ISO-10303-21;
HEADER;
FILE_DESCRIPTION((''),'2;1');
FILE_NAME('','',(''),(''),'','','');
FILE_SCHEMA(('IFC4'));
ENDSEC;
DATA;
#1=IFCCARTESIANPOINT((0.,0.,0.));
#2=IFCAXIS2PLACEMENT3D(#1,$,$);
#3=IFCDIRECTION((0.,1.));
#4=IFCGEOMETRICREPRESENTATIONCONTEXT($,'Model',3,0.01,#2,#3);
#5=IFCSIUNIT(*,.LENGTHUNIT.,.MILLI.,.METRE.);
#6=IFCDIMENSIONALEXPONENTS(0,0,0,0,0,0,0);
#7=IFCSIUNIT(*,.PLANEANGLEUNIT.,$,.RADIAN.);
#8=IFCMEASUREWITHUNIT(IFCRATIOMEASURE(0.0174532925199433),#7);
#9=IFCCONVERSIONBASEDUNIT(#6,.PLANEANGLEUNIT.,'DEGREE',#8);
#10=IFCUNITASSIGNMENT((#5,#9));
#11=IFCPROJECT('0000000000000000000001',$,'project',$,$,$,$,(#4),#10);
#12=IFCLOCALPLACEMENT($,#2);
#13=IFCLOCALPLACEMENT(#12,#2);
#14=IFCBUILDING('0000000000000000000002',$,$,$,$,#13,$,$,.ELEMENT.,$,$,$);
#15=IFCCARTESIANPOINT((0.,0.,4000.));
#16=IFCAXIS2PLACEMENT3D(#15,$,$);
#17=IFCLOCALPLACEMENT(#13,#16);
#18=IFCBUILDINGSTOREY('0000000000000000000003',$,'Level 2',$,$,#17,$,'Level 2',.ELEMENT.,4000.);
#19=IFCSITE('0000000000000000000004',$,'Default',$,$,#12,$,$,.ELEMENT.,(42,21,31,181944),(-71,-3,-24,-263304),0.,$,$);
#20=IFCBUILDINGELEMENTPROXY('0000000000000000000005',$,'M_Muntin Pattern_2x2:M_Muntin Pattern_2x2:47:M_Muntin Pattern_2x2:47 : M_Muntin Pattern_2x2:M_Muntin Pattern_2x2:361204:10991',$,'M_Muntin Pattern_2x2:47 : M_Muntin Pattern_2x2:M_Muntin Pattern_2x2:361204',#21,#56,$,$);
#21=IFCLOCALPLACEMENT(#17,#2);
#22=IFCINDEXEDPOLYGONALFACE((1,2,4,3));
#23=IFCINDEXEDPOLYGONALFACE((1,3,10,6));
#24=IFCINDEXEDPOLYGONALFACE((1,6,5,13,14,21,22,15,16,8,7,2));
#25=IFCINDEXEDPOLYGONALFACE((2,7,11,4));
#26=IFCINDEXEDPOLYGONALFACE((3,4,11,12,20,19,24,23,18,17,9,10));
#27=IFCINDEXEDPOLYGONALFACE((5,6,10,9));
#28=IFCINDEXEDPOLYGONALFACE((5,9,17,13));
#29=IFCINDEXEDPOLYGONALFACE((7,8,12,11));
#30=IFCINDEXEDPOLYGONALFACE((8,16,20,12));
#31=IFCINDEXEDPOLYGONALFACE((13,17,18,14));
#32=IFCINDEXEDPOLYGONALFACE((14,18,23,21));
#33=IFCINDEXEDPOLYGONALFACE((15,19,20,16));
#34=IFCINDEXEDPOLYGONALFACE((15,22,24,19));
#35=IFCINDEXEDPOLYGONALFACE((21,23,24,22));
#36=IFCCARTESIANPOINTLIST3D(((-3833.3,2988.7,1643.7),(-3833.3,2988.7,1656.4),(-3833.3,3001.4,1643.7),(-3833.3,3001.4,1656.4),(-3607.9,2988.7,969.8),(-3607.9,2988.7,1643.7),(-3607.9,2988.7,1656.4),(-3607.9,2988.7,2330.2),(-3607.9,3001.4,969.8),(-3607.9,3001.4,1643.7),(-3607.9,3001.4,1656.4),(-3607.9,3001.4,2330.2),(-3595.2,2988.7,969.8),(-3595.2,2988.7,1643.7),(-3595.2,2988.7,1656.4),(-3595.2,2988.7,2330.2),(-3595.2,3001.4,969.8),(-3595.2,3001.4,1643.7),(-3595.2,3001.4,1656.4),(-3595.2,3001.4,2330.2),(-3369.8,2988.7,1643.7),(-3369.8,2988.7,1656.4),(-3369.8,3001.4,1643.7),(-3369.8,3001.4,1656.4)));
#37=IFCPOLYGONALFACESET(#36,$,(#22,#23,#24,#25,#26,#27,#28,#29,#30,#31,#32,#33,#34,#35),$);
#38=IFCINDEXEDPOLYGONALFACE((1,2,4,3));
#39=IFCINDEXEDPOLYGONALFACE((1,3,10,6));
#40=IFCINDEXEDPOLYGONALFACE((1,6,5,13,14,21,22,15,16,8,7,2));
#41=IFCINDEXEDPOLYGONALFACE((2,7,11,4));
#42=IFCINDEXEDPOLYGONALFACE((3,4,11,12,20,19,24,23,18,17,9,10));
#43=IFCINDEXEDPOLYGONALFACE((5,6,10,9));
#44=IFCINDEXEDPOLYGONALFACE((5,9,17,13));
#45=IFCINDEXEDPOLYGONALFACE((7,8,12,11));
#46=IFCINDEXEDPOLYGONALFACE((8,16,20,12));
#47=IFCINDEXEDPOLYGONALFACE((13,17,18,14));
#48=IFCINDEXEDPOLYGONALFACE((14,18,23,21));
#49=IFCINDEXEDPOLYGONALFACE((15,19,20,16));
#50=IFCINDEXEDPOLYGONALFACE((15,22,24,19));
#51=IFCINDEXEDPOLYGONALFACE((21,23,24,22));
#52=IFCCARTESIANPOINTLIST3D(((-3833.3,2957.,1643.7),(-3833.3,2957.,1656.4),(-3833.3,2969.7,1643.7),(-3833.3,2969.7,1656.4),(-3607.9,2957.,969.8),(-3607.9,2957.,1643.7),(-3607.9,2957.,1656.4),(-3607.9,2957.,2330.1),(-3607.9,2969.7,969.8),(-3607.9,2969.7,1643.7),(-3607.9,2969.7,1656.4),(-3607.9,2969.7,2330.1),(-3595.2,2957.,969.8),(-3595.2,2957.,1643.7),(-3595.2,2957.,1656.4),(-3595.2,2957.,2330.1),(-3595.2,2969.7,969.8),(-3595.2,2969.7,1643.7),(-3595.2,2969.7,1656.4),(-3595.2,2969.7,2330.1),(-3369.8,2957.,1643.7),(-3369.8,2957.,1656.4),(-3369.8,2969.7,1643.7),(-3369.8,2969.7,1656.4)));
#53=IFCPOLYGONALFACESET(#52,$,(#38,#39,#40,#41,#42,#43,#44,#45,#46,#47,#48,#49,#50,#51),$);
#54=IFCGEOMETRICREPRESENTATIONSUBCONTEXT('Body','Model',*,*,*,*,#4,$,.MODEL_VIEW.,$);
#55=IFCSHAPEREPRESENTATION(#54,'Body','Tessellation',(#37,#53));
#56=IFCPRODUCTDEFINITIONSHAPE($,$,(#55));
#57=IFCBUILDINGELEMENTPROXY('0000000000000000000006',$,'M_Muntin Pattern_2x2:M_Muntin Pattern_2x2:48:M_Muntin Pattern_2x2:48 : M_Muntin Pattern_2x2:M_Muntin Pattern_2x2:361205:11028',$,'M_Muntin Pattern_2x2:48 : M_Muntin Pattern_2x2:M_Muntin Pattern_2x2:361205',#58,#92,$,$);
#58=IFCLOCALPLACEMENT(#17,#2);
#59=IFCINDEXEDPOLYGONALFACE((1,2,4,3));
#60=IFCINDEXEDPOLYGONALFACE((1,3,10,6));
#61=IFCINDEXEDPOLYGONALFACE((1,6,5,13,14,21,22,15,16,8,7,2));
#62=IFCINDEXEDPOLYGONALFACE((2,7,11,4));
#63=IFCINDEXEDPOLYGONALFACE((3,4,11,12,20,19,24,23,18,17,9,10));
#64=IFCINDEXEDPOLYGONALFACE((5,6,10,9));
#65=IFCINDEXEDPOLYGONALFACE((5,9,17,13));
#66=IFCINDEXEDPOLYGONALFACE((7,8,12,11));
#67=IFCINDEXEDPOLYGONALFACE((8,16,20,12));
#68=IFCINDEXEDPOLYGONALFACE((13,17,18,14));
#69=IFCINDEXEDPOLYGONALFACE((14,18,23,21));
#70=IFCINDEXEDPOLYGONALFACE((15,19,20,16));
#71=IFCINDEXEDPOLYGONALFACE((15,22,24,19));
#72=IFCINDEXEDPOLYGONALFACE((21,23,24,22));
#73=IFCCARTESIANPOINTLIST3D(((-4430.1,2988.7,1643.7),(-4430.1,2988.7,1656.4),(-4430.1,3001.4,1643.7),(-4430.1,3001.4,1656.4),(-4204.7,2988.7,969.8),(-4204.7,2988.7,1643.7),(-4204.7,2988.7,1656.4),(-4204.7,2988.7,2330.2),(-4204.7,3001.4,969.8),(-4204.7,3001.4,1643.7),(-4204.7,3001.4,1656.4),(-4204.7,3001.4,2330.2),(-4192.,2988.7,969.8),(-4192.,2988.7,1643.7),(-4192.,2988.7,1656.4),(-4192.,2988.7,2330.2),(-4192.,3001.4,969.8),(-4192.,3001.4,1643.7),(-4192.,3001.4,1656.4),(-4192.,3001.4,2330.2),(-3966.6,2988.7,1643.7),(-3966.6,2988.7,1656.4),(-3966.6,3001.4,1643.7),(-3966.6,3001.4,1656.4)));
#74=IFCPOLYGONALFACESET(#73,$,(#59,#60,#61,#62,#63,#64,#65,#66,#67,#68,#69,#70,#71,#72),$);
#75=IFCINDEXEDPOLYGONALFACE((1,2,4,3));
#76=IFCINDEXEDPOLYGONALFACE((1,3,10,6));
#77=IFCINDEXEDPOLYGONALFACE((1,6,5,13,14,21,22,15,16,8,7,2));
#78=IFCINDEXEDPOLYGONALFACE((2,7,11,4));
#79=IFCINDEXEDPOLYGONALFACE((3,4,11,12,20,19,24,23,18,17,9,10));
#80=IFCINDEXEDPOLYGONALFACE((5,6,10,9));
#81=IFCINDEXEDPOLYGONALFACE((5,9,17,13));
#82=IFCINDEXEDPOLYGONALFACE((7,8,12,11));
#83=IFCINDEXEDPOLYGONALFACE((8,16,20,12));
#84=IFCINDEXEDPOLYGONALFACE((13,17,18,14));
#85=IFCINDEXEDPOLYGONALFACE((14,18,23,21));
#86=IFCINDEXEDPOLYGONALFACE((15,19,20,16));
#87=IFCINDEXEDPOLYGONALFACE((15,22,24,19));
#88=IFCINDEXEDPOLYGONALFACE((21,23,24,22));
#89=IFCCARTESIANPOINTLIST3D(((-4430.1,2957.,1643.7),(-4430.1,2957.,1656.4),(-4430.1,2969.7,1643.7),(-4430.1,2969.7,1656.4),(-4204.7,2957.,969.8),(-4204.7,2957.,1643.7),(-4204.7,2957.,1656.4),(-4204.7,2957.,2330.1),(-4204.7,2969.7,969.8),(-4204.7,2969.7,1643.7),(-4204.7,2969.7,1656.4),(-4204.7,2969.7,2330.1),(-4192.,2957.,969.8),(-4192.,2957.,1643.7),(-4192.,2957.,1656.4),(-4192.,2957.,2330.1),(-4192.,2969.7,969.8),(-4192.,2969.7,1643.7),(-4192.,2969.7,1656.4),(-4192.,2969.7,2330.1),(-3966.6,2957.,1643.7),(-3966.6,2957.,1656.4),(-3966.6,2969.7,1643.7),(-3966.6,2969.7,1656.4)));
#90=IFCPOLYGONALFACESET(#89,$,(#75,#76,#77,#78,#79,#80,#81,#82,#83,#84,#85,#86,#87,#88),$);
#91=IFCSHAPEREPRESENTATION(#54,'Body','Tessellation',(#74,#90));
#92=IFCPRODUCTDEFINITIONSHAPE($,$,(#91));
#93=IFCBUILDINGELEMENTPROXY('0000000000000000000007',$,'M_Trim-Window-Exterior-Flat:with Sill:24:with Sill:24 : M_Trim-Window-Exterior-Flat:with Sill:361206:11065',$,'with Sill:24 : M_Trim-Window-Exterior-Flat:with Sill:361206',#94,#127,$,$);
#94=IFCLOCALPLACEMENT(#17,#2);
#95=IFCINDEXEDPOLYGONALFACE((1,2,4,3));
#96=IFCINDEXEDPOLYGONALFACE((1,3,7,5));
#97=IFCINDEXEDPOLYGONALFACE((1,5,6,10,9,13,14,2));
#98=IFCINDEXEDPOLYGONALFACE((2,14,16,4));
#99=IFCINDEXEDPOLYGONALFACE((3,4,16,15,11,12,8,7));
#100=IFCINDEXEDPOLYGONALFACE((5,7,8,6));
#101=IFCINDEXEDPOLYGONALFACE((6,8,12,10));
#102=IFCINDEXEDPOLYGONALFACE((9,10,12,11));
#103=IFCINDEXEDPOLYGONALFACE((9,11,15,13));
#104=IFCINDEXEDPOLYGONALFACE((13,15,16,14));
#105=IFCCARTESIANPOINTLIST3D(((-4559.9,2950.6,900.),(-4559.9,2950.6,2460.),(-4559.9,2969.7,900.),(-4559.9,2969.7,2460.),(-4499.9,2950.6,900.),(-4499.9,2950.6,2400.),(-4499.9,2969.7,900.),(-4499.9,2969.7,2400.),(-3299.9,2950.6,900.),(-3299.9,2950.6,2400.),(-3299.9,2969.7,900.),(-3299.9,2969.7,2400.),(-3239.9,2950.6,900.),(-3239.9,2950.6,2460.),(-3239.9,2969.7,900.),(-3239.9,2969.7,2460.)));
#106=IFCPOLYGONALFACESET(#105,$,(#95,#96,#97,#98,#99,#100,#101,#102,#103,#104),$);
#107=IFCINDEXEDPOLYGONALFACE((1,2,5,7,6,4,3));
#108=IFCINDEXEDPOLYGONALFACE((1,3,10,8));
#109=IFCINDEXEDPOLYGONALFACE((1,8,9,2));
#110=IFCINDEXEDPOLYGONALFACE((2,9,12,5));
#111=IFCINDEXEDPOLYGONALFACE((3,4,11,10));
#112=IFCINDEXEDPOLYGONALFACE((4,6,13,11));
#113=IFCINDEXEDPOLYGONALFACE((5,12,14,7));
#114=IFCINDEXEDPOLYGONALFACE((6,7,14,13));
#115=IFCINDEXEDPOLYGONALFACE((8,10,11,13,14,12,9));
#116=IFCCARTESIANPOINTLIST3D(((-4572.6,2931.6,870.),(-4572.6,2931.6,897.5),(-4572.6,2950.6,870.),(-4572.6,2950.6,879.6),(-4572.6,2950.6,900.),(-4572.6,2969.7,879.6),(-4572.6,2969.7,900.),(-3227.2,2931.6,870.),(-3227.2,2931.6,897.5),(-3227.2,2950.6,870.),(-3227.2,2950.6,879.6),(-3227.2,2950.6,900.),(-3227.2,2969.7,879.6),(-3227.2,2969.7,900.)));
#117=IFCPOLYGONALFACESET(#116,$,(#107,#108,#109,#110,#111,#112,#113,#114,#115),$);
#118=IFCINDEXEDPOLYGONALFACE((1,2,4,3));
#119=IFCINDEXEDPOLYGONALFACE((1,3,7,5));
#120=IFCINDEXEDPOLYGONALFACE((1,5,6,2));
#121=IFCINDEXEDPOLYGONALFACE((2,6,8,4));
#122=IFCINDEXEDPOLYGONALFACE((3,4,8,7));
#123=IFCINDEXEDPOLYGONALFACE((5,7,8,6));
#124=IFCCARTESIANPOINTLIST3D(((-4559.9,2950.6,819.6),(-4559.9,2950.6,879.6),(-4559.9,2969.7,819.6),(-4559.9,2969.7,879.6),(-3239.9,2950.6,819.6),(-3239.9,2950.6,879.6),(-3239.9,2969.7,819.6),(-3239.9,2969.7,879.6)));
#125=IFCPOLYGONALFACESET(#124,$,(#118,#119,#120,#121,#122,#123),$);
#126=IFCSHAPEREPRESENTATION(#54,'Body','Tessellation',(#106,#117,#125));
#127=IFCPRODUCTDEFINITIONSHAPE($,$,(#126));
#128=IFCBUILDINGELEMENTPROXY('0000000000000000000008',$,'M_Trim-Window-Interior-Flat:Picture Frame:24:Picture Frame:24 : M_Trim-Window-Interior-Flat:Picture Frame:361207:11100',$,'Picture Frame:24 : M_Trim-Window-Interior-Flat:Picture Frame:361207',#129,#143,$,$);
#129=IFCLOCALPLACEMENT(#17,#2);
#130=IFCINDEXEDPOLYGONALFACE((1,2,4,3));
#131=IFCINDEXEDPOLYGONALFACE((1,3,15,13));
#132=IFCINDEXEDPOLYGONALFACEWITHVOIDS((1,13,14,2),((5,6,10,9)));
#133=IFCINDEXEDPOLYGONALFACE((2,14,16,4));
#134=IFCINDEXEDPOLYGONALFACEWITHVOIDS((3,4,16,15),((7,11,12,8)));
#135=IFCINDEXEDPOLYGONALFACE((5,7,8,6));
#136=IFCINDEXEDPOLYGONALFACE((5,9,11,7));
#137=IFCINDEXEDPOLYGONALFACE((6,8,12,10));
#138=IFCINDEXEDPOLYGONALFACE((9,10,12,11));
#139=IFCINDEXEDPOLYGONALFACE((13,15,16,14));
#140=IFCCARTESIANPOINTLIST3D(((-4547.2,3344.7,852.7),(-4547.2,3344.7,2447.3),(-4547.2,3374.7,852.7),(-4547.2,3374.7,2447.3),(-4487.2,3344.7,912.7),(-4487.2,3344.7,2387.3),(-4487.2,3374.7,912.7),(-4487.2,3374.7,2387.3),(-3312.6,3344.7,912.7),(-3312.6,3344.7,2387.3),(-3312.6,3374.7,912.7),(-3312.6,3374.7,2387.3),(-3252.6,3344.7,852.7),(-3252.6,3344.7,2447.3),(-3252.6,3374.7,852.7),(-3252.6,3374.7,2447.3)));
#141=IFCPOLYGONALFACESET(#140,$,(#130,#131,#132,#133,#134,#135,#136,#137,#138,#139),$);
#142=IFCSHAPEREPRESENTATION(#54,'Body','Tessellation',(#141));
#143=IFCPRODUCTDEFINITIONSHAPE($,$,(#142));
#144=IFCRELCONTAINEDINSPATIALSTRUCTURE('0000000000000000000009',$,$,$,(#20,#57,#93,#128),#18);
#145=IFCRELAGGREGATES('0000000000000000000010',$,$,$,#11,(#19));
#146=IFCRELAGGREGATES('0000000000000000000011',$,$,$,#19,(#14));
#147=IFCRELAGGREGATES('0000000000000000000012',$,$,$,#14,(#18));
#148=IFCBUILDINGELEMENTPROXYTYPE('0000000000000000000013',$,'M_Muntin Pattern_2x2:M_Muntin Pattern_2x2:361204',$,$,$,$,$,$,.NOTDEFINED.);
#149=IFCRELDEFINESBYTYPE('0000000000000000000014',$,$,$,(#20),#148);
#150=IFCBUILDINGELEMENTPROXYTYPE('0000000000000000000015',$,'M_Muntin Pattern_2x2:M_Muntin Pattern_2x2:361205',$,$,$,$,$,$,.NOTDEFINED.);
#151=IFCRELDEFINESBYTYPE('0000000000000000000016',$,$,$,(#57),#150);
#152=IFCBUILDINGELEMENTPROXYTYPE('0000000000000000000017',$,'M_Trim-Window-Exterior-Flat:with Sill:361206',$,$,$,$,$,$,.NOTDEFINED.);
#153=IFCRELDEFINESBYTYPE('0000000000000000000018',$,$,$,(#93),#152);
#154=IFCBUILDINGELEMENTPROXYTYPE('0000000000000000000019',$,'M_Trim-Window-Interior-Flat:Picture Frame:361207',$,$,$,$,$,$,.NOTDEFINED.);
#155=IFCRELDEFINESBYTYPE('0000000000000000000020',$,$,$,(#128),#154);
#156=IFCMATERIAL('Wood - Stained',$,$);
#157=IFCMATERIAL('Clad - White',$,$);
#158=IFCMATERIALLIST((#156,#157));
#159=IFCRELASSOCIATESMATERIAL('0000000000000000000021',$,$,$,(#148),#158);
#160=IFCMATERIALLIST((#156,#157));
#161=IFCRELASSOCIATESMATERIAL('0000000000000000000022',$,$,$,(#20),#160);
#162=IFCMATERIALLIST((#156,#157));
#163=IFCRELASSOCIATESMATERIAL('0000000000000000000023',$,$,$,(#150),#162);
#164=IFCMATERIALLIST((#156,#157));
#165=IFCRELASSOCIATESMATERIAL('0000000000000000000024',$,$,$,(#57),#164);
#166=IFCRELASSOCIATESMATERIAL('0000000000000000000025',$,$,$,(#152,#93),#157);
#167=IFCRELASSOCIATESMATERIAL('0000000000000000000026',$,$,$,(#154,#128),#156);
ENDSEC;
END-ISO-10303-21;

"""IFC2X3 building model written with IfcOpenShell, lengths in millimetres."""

from ifc_helpers import new_model, entity, si_unit, converted_unit, direction, frame, origin, origin_2d_with_axis, place, context, subcontext, project, spatial, polyline, rectangle, outline, extrude, source, transform, mapped, material, material_list, type_object, type_shapes, element, save


model = new_model("IFC2X3")

# Units and contexts
model_context = context("Model", 3, precision=0.01, world=origin(), true_north=direction((0.0, 1.0)))
body_context = subcontext(model_context, "Body", "Model", "MODEL_VIEW")
ifc_project = project(units=[si_unit("LENGTHUNIT", "METRE", prefix="MILLI"), converted_unit("PLANEANGLEUNIT", "DEGREE", entity("IfcRatioMeasure", 0.0174532925199433), si_unit("PLANEANGLEUNIT", "RADIAN"), dimensions=[0, 0, 0, 0, 0, 0, 0])], contexts=[model_context])

# Site, building, storey
site_placement = place(None, origin())
site = spatial("IfcSite", under=ifc_project, at=site_placement, Name="Default", CompositionType="ELEMENT", RefLatitude=(42, 21, 31, 181944), RefLongitude=(-71, -3, -24, -263304), RefElevation=0.0)
building_placement = place(site_placement, origin())
building = spatial("IfcBuilding", under=site, at=building_placement, CompositionType="ELEMENT")
storey_placement = place(building_placement, frame((0.0, 0.0, 4000.0)))
storey = spatial("IfcBuildingStorey", under=building, at=storey_placement, Name="Level 2", LongName="Level 2", CompositionType="ELEMENT", Elevation=4000.0)

# Building element proxies
ifc_material_1 = material(Name="Wood - Stained")
ifc_material_2 = material(Name="Clad - White")
ifc_material_list_1 = material_list([ifc_material_1, ifc_material_2])
ifc_material_list_2 = material_list([ifc_material_1, ifc_material_2])
building_element_proxy_type_1 = type_object("IfcBuildingElementProxyType", Name="M_Muntin Pattern_2x2:M_Muntin Pattern_2x2:361204", PredefinedType="NOTDEFINED", material=ifc_material_list_2)
shared_shape_1 = source(origin(), body_context, "Body", "SweptSolid", [
    extrude(outline(polyline([(-680.2, 6.4), (-680.2, -6.3), (-6.4, -6.3), (-6.4, -231.7), (6.3, -231.7), (6.3, -6.3), (680.2, -6.3), (680.2, 6.4), (6.3, 6.4), (6.3, 231.7), (-6.4, 231.7), (-6.4, 6.4), (-680.2, 6.4)])), frame((-3601.5, 2988.7, 5650.0), z_axis=(0.0, -1.0, 0.0), x_axis=(0.0, 0.0, -1.0)), (0.0, 0.0, -1.0), 12.7),
    extrude(outline(polyline([(-680.1, 6.4), (-680.1, -6.3), (-6.4, -6.3), (-6.4, -231.7), (6.3, -231.7), (6.3, -6.3), (680.2, -6.3), (680.2, 6.4), (6.3, 6.4), (6.3, 231.7), (-6.4, 231.7), (-6.4, 6.4), (-680.1, 6.4)])), frame((-3601.5, 2957.0, 5650.0), z_axis=(0.0, -1.0, 0.0), x_axis=(0.0, 0.0, -1.0)), (0.0, 0.0, -1.0), 12.7),
])
type_shapes(building_element_proxy_type_1, [shared_shape_1])
proxy_1_placement = place(storey_placement, frame((0.0, 0.0, -4000.0)))
element("IfcBuildingElementProxy", 1, at=proxy_1_placement, inside=storey, type_object=building_element_proxy_type_1, material=ifc_material_list_1, Name="M_Muntin Pattern_2x2:M_Muntin Pattern_2x2:47:M_Muntin Pattern_2x2:47 : M_Muntin Pattern_2x2:M_Muntin Pattern_2x2:361204:10991", ObjectType="M_Muntin Pattern_2x2:47 : M_Muntin Pattern_2x2:M_Muntin Pattern_2x2:361204", context=body_context, shape_type="MappedRepresentation", body=[
    mapped(shared_shape_1, transform((0.0, 0.0, 0.0), scale=1.0)),
])
ifc_material_list_3 = material_list([ifc_material_1, ifc_material_2])
ifc_material_list_4 = material_list([ifc_material_1, ifc_material_2])
building_element_proxy_type_2 = type_object("IfcBuildingElementProxyType", Name="M_Muntin Pattern_2x2:M_Muntin Pattern_2x2:361205", PredefinedType="NOTDEFINED", material=ifc_material_list_4)
shared_shape_2 = source(origin(), body_context, "Body", "SweptSolid", [
    extrude(outline(polyline([(-6.4, -680.1), (6.3, -680.1), (6.3, -6.4), (231.7, -6.4), (231.7, 6.3), (6.3, 6.3), (6.3, 680.2), (-6.4, 680.2), (-6.4, 6.3), (-231.7, 6.3), (-231.7, -6.4), (-6.4, -6.4), (-6.4, -680.1)])), frame((-4198.4, 2988.7, 5650.0), z_axis=(0.0, 1.0, 0.0), x_axis=(1.0, 0.0, 0.0)), (0.0, 0.0, 1.0), 12.7),
    extrude(outline(polyline([(-6.4, -680.1), (6.3, -680.1), (6.3, -6.4), (231.7, -6.4), (231.7, 6.3), (6.3, 6.3), (6.3, 680.2), (-6.4, 680.2), (-6.4, 6.3), (-231.7, 6.3), (-231.7, -6.4), (-6.4, -6.4), (-6.4, -680.1)])), frame((-4198.4, 2957.0, 5650.0), z_axis=(0.0, 1.0, 0.0), x_axis=(1.0, 0.0, 0.0)), (0.0, 0.0, 1.0), 12.7),
])
type_shapes(building_element_proxy_type_2, [shared_shape_2])
proxy_2_placement = place(storey_placement, frame((0.0, 0.0, -4000.0)))
element("IfcBuildingElementProxy", 2, at=proxy_2_placement, inside=storey, type_object=building_element_proxy_type_2, material=ifc_material_list_3, Name="M_Muntin Pattern_2x2:M_Muntin Pattern_2x2:48:M_Muntin Pattern_2x2:48 : M_Muntin Pattern_2x2:M_Muntin Pattern_2x2:361205:11028", ObjectType="M_Muntin Pattern_2x2:48 : M_Muntin Pattern_2x2:M_Muntin Pattern_2x2:361205", context=body_context, shape_type="MappedRepresentation", body=[
    mapped(shared_shape_2, transform((0.0, 0.0, 0.0), scale=1.0)),
])
building_element_proxy_type_3 = type_object("IfcBuildingElementProxyType", Name="M_Trim-Window-Exterior-Flat:with Sill:361206", PredefinedType="NOTDEFINED", material=ifc_material_2)
shared_shape_3 = source(origin(), body_context, "Body", "SweptSolid", [
    extrude(outline(polyline([(-765.0, -660.0), (795.0, -660.0), (795.0, 660.0), (-765.0, 660.0), (-765.0, 600.0), (735.0, 600.0), (735.0, -600.0), (-765.0, -600.0), (-765.0, -660.0)])), frame((-3899.9, 2950.6, 5665.0), z_axis=(0.0, 1.0, 0.0), x_axis=(0.0, 0.0, 1.0)), (0.0, 0.0, 1.0), 19.1),
    extrude(outline(polyline([(-15.2, 0.0), (-15.2, -19.0), (12.3, -19.0), (14.8, 0.0), (14.8, 19.0), (-5.7, 19.0), (-5.7, 0.0), (-15.2, 0.0)])), frame((-4572.6, 2950.6, 4885.2), z_axis=(-1.0, 0.0, 0.0), x_axis=(0.0, 0.0, 1.0)), (0.0, 0.0, -1.0), 1345.4),
    extrude(rectangle(XDim=19.1, YDim=1320.0, at=origin_2d_with_axis()), frame((-3899.9, 2960.1, 4819.6), z_axis=(0.0, 0.0, 1.0), x_axis=(0.0, 1.0, 0.0)), (0.0, 0.0, 1.0), 60.0),
])
type_shapes(building_element_proxy_type_3, [shared_shape_3])
proxy_3_placement = place(storey_placement, frame((0.0, 0.0, -4000.0)))
element("IfcBuildingElementProxy", 3, at=proxy_3_placement, inside=storey, type_object=building_element_proxy_type_3, material=ifc_material_2, Name="M_Trim-Window-Exterior-Flat:with Sill:24:with Sill:24 : M_Trim-Window-Exterior-Flat:with Sill:361206:11065", ObjectType="with Sill:24 : M_Trim-Window-Exterior-Flat:with Sill:361206", context=body_context, shape_type="MappedRepresentation", body=[
    mapped(shared_shape_3, transform((0.0, 0.0, 0.0), scale=1.0)),
])
building_element_proxy_type_4 = type_object("IfcBuildingElementProxyType", Name="M_Trim-Window-Interior-Flat:Picture Frame:361207", PredefinedType="NOTDEFINED", material=ifc_material_1)
shared_shape_4 = source(origin(), body_context, "Body", "SweptSolid", [
    extrude(outline(polyline([(-797.3, -647.3), (797.3, -647.3), (797.3, 647.3), (-797.3, 647.3), (-797.3, -647.3)]), holes=[polyline([(737.3, 587.3), (737.3, -587.3), (-737.3, -587.3), (-737.3, 587.3), (737.3, 587.3)])]), frame((-3899.9, 3344.7, 5650.0), z_axis=(0.0, 1.0, 0.0), x_axis=(0.0, 0.0, -1.0)), (0.0, 0.0, 1.0), 30.0),
])
type_shapes(building_element_proxy_type_4, [shared_shape_4])
proxy_4_placement = place(storey_placement, frame((0.0, 0.0, -4000.0)))
element("IfcBuildingElementProxy", 4, at=proxy_4_placement, inside=storey, type_object=building_element_proxy_type_4, material=ifc_material_1, Name="M_Trim-Window-Interior-Flat:Picture Frame:24:Picture Frame:24 : M_Trim-Window-Interior-Flat:Picture Frame:361207:11100", ObjectType="Picture Frame:24 : M_Trim-Window-Interior-Flat:Picture Frame:361207", context=body_context, shape_type="MappedRepresentation", body=[
    mapped(shared_shape_4, transform((0.0, 0.0, 0.0), scale=1.0)),
])

save(model, "model.ifc")
